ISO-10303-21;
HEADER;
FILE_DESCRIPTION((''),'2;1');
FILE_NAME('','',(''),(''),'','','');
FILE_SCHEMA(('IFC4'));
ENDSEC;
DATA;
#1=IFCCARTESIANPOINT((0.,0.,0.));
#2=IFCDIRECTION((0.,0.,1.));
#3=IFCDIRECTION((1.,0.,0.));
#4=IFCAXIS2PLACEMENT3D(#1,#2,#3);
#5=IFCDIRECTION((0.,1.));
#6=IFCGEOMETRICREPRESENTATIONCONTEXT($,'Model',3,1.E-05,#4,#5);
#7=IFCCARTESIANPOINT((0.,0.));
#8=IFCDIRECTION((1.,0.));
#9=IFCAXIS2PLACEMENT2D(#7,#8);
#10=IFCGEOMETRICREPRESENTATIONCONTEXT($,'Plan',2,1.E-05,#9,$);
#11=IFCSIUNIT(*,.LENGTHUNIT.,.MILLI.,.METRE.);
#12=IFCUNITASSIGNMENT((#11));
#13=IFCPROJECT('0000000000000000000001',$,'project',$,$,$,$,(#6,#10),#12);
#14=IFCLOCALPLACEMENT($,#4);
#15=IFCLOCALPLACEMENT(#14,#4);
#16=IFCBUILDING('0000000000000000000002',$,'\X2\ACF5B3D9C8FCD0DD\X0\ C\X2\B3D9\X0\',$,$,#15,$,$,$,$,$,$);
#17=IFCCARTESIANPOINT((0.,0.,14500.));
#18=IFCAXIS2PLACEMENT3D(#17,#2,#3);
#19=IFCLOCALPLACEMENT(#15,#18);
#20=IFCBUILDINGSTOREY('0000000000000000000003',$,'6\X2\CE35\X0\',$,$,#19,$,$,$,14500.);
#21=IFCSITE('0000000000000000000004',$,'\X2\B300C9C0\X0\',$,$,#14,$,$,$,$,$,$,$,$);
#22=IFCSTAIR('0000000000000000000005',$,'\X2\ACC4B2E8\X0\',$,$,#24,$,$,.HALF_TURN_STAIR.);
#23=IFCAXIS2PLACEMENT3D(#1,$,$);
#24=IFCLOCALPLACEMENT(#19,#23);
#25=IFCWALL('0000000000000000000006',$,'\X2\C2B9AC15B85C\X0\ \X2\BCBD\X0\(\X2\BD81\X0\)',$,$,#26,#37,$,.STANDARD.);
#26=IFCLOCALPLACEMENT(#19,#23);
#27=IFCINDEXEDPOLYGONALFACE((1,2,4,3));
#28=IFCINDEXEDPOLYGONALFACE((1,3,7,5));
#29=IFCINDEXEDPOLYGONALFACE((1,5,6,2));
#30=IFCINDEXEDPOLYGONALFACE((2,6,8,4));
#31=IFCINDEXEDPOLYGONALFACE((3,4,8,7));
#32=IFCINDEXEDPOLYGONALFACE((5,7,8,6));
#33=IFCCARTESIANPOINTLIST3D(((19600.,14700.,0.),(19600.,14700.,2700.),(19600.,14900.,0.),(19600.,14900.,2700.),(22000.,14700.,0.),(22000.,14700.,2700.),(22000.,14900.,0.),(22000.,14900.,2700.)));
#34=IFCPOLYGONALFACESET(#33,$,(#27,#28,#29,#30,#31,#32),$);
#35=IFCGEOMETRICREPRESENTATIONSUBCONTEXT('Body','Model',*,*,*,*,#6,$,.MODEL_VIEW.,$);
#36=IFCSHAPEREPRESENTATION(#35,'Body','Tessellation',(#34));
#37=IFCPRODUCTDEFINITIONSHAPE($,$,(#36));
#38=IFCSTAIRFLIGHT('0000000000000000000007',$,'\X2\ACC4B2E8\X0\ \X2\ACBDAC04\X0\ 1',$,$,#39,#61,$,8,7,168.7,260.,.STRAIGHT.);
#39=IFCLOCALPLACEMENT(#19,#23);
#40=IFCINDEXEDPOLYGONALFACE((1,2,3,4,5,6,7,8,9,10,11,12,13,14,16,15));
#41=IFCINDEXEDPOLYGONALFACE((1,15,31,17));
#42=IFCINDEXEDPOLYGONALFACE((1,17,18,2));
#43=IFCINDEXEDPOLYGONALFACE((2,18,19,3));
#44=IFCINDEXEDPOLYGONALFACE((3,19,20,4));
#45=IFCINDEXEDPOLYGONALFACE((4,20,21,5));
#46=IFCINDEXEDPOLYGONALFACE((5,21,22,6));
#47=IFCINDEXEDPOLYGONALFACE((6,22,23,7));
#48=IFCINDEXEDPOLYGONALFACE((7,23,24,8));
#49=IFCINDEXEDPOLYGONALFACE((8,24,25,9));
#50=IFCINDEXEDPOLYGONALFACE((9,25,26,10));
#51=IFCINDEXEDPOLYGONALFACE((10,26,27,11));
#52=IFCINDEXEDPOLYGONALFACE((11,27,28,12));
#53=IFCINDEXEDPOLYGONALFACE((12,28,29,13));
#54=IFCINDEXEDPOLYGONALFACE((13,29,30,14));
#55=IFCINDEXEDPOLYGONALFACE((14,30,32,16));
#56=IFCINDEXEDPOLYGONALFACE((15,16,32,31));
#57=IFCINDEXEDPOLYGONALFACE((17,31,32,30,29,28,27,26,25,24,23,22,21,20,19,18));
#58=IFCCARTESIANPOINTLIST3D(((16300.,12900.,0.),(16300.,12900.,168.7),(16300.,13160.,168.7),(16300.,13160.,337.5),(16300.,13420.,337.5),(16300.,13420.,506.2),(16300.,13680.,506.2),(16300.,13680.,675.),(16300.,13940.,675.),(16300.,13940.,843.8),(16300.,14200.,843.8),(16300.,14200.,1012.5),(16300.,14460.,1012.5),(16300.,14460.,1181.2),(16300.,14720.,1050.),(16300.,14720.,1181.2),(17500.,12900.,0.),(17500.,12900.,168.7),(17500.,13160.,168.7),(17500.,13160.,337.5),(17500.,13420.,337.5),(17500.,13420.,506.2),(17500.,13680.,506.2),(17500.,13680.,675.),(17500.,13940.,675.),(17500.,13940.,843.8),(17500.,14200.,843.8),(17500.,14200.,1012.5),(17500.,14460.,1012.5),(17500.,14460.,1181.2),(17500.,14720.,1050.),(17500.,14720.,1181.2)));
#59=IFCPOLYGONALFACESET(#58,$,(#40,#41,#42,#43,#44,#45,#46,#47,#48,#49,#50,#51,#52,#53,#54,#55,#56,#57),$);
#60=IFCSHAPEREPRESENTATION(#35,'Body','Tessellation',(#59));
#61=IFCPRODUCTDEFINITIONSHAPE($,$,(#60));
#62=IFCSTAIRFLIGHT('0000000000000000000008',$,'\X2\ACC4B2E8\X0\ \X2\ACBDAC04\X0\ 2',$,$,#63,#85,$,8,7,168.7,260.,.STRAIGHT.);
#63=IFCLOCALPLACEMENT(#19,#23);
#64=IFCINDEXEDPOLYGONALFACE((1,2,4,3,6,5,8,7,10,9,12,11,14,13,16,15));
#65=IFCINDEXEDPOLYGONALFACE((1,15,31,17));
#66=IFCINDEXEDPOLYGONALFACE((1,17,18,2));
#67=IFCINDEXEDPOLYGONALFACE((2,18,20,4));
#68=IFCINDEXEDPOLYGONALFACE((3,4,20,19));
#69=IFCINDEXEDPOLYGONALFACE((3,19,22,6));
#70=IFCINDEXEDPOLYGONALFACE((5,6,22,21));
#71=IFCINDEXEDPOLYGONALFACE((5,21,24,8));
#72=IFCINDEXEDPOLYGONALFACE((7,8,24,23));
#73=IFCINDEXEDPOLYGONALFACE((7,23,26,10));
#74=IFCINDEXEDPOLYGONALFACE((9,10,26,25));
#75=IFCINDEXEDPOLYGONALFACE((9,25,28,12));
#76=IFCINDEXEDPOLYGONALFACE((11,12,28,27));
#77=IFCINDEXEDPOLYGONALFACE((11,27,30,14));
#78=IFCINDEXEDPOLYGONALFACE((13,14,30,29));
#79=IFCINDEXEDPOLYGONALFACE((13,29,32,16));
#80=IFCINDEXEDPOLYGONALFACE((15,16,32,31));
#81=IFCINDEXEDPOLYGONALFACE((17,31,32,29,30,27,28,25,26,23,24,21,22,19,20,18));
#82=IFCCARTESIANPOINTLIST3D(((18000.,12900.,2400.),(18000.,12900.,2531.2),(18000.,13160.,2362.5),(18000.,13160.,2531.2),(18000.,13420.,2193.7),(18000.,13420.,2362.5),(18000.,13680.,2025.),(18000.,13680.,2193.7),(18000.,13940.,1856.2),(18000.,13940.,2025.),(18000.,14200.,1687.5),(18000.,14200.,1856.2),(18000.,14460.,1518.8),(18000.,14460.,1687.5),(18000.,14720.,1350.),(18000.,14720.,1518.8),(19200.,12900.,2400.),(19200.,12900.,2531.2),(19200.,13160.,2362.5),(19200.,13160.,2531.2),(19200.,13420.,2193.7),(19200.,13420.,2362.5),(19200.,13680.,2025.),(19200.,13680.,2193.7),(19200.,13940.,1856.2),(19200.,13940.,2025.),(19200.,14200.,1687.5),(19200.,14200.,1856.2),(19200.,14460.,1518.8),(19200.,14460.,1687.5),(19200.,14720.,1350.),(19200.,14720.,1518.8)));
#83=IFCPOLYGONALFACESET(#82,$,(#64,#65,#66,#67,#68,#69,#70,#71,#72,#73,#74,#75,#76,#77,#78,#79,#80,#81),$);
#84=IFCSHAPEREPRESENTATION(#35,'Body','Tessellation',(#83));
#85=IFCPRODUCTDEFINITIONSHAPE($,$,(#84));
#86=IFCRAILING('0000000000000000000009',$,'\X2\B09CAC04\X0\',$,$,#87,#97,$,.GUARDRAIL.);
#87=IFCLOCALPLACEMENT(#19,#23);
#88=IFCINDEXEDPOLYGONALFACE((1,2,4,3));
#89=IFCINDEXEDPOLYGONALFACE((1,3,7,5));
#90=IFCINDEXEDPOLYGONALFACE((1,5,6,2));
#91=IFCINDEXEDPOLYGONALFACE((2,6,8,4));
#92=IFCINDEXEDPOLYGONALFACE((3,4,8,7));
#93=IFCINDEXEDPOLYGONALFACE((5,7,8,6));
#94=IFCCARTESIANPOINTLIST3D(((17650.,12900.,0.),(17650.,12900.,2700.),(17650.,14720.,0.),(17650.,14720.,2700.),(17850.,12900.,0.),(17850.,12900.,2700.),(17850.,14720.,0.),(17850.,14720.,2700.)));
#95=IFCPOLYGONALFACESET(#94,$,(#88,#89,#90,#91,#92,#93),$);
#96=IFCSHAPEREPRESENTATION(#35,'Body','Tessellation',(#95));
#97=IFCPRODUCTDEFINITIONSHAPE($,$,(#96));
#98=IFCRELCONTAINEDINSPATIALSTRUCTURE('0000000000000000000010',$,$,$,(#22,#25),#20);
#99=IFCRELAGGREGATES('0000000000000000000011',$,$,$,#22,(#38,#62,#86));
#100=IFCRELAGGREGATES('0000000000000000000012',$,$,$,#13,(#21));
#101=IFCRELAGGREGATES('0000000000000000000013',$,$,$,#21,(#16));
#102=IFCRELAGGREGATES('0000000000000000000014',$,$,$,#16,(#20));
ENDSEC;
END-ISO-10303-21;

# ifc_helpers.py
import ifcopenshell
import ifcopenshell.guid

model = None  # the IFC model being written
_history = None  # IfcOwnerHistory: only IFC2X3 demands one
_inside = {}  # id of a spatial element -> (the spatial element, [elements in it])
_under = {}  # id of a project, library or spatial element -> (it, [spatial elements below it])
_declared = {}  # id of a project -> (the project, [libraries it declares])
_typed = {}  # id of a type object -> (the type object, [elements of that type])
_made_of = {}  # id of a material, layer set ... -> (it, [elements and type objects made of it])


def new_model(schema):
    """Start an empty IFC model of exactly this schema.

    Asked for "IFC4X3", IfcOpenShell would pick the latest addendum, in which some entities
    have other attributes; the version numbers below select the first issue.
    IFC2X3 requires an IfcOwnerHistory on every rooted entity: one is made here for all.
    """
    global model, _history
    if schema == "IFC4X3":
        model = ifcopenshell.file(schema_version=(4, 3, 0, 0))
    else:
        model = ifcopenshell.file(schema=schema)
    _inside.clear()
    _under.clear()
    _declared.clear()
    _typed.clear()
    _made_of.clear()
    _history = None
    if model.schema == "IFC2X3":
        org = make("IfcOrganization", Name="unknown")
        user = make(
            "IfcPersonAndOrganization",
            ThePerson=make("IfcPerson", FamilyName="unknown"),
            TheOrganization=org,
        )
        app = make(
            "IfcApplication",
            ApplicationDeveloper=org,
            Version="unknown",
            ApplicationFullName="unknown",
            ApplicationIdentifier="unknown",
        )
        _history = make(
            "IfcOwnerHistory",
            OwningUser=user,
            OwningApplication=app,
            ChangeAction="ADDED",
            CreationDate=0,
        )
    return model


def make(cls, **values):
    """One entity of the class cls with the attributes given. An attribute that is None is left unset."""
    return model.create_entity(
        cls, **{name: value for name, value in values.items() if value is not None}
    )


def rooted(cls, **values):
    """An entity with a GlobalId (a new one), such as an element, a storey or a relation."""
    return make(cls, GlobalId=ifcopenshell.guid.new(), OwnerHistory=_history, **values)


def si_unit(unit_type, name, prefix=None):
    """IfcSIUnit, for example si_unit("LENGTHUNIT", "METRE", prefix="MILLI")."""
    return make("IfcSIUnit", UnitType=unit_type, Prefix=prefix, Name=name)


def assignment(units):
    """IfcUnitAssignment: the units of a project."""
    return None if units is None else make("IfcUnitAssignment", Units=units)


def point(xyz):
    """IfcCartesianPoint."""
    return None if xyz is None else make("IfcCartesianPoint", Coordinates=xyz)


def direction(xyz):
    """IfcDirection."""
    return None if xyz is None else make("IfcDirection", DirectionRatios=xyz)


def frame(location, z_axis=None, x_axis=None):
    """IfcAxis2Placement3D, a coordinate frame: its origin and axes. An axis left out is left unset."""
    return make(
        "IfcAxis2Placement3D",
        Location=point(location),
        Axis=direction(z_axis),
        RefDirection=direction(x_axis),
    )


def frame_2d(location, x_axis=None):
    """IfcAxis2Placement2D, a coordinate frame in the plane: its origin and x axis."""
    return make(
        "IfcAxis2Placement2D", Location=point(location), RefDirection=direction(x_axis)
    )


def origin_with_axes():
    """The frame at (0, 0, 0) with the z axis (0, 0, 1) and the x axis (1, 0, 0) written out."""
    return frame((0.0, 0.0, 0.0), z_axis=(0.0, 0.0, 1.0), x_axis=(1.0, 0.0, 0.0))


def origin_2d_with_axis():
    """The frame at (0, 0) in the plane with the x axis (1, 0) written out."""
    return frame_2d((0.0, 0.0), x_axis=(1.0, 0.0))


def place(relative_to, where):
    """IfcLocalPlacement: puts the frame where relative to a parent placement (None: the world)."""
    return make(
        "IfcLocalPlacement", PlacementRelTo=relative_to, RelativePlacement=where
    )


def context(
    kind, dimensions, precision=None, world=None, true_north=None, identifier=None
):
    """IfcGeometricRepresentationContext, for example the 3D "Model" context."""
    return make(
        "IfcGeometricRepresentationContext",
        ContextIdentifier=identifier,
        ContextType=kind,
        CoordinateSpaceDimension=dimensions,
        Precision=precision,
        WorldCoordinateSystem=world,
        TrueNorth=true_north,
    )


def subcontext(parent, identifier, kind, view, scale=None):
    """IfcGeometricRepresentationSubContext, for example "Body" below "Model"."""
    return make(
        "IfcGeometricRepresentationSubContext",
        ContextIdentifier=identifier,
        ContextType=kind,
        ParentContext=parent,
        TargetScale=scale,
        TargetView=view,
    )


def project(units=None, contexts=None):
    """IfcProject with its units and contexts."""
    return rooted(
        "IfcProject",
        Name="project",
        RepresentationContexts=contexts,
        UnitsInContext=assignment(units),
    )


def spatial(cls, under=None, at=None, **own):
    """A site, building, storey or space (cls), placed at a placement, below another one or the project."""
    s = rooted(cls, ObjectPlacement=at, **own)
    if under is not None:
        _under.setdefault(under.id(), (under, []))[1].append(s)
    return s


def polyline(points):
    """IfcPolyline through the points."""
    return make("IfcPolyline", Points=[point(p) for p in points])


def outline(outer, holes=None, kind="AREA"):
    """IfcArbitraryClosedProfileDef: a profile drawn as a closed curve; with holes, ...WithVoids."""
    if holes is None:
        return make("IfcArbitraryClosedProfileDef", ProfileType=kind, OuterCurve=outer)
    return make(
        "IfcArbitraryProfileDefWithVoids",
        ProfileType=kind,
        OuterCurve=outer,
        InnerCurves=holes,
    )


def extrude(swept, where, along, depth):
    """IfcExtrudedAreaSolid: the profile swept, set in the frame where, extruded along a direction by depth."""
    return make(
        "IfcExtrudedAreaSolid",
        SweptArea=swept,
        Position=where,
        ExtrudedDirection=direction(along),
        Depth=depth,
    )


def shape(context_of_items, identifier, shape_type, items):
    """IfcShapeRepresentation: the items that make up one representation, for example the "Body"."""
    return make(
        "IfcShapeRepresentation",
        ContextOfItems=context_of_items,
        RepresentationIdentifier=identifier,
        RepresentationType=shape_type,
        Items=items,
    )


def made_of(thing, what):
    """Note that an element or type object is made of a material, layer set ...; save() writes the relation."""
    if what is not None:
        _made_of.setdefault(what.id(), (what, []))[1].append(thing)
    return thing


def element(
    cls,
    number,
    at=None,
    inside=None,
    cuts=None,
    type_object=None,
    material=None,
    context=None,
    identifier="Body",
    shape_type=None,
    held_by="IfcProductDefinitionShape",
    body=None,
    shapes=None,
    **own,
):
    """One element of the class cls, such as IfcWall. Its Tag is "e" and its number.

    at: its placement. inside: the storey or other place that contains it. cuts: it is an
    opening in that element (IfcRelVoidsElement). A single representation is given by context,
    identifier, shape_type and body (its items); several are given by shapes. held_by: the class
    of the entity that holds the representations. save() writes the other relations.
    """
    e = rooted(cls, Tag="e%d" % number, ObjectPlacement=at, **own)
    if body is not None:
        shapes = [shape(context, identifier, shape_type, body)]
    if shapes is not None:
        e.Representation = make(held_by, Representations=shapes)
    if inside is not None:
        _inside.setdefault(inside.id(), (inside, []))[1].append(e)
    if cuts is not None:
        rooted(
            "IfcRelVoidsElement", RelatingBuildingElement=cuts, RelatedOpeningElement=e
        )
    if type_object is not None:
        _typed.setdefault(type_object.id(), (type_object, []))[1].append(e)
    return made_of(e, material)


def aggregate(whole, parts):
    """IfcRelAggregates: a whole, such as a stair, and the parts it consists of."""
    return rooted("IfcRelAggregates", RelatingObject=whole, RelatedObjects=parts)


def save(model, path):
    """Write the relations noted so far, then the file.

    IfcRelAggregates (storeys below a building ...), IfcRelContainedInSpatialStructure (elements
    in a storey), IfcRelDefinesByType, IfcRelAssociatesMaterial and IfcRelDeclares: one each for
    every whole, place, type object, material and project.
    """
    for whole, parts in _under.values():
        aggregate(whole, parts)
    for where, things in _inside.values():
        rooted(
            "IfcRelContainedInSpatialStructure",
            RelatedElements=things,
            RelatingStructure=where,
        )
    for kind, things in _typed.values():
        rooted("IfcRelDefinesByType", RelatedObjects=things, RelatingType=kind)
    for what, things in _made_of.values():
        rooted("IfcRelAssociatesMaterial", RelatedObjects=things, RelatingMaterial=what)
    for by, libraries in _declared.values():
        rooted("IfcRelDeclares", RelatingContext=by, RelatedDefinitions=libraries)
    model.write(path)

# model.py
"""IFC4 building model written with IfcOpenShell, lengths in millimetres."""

from ifc_helpers import new_model, si_unit, direction, frame, origin_with_axes, origin_2d_with_axis, place, context, subcontext, project, spatial, polyline, outline, extrude, element, aggregate, save


model = new_model("IFC4")

# Units and contexts
model_context = context("Model", 3, precision=1e-05, world=origin_with_axes(), true_north=direction((0.0, 1.0)))
plan_context = context("Plan", 2, precision=1e-05, world=origin_2d_with_axis())
body_context = subcontext(model_context, "Body", "Model", "MODEL_VIEW")
ifc_project = project(units=[si_unit("LENGTHUNIT", "METRE", prefix="MILLI")], contexts=[model_context, plan_context])

# Site, building, storey
site_placement = place(None, origin_with_axes())
site = spatial("IfcSite", under=ifc_project, at=site_placement, Name="대지")
building_placement = place(site_placement, origin_with_axes())
building = spatial("IfcBuilding", under=site, at=building_placement, Name="공동주택 C동")
storey_placement = place(building_placement, frame((0.0, 0.0, 14500.0), z_axis=(0.0, 0.0, 1.0), x_axis=(1.0, 0.0, 0.0)))
storey = spatial("IfcBuildingStorey", under=building, at=storey_placement, Name="6층", Elevation=14500.0)

# Stair
stair_placement = place(storey_placement, origin_with_axes())
stair = element("IfcStair", 1, at=stair_placement, inside=storey, Name="계단", PredefinedType="HALF_TURN_STAIR")

# Wall
wall_1_placement = place(storey_placement, origin_with_axes())
element("IfcWall", 2, at=wall_1_placement, inside=storey, Name="승강로 벽(북)", PredefinedType="STANDARD", context=body_context, shape_type="SweptSolid", body=[
    extrude(outline(polyline([(19600.0, 14900.0), (22000.0, 14900.0), (22000.0, 14700.0), (19600.0, 14700.0), (19600.0, 14900.0)])), origin_with_axes(), (0.0, 0.0, 1.0), 2700.0),
])

# Stair flights
stair_flight_1_placement = place(stair_placement, origin_with_axes())
stair_flight_1 = element("IfcStairFlight", 3, at=stair_flight_1_placement, Name="계단 경간 1", NumberOfRisers=8, NumberOfTreads=7, PredefinedType="STRAIGHT", RiserHeight=168.7, TreadLength=260.0, context=body_context, shape_type="SweptSolid", body=[
    extrude(outline(polyline([(0.0, 0.0), (0.0, 168.7), (260.0, 168.7), (260.0, 337.5), (520.0, 337.5), (520.0, 506.2), (780.0, 506.2), (780.0, 675.0), (1040.0, 675.0), (1040.0, 843.7), (1300.0, 843.7), (1300.0, 1012.5), (1560.0, 1012.5), (1560.0, 1181.2), (1820.0, 1181.2), (1820.0, 1350.0), (1820.0, 1050.0), (0.0, 0.0)])), frame((16300.0, 12900.0, 0.0), z_axis=(1.0, 0.0, 0.0), x_axis=(0.0, 1.0, 0.0)), (0.0, 0.0, 1.0), 1200.0),
])
stair_flight_2_placement = place(stair_placement, origin_with_axes())
stair_flight_2 = element("IfcStairFlight", 4, at=stair_flight_2_placement, Name="계단 경간 2", NumberOfRisers=8, NumberOfTreads=7, PredefinedType="STRAIGHT", RiserHeight=168.7, TreadLength=260.0, context=body_context, shape_type="SweptSolid", body=[
    extrude(outline(polyline([(0.0, 0.0), (0.0, 168.7), (260.0, 168.7), (260.0, 337.5), (520.0, 337.5), (520.0, 506.2), (780.0, 506.2), (780.0, 675.0), (1040.0, 675.0), (1040.0, 843.7), (1300.0, 843.7), (1300.0, 1012.5), (1560.0, 1012.5), (1560.0, 1181.2), (1820.0, 1181.2), (1820.0, 1350.0), (1820.0, 1050.0), (0.0, 0.0)])), frame((19200.0, 14720.0, 1350.0), z_axis=(-1.0, 0.0, 0.0), x_axis=(0.0, -1.0, 0.0)), (0.0, 0.0, 1.0), 1200.0),
])

# Railing
railing_placement = place(stair_placement, origin_with_axes())
railing = element("IfcRailing", 5, at=railing_placement, Name="난간", PredefinedType="GUARDRAIL", context=body_context, shape_type="SweptSolid", body=[
    extrude(outline(polyline([(17650.0, 12900.0), (17850.0, 12900.0), (17850.0, 14720.0), (17650.0, 14720.0), (17650.0, 12900.0)])), origin_with_axes(), (0.0, 0.0, 1.0), 2700.0),
])
aggregate(stair, [stair_flight_1, stair_flight_2, railing])

save(model, "model.ifc")
